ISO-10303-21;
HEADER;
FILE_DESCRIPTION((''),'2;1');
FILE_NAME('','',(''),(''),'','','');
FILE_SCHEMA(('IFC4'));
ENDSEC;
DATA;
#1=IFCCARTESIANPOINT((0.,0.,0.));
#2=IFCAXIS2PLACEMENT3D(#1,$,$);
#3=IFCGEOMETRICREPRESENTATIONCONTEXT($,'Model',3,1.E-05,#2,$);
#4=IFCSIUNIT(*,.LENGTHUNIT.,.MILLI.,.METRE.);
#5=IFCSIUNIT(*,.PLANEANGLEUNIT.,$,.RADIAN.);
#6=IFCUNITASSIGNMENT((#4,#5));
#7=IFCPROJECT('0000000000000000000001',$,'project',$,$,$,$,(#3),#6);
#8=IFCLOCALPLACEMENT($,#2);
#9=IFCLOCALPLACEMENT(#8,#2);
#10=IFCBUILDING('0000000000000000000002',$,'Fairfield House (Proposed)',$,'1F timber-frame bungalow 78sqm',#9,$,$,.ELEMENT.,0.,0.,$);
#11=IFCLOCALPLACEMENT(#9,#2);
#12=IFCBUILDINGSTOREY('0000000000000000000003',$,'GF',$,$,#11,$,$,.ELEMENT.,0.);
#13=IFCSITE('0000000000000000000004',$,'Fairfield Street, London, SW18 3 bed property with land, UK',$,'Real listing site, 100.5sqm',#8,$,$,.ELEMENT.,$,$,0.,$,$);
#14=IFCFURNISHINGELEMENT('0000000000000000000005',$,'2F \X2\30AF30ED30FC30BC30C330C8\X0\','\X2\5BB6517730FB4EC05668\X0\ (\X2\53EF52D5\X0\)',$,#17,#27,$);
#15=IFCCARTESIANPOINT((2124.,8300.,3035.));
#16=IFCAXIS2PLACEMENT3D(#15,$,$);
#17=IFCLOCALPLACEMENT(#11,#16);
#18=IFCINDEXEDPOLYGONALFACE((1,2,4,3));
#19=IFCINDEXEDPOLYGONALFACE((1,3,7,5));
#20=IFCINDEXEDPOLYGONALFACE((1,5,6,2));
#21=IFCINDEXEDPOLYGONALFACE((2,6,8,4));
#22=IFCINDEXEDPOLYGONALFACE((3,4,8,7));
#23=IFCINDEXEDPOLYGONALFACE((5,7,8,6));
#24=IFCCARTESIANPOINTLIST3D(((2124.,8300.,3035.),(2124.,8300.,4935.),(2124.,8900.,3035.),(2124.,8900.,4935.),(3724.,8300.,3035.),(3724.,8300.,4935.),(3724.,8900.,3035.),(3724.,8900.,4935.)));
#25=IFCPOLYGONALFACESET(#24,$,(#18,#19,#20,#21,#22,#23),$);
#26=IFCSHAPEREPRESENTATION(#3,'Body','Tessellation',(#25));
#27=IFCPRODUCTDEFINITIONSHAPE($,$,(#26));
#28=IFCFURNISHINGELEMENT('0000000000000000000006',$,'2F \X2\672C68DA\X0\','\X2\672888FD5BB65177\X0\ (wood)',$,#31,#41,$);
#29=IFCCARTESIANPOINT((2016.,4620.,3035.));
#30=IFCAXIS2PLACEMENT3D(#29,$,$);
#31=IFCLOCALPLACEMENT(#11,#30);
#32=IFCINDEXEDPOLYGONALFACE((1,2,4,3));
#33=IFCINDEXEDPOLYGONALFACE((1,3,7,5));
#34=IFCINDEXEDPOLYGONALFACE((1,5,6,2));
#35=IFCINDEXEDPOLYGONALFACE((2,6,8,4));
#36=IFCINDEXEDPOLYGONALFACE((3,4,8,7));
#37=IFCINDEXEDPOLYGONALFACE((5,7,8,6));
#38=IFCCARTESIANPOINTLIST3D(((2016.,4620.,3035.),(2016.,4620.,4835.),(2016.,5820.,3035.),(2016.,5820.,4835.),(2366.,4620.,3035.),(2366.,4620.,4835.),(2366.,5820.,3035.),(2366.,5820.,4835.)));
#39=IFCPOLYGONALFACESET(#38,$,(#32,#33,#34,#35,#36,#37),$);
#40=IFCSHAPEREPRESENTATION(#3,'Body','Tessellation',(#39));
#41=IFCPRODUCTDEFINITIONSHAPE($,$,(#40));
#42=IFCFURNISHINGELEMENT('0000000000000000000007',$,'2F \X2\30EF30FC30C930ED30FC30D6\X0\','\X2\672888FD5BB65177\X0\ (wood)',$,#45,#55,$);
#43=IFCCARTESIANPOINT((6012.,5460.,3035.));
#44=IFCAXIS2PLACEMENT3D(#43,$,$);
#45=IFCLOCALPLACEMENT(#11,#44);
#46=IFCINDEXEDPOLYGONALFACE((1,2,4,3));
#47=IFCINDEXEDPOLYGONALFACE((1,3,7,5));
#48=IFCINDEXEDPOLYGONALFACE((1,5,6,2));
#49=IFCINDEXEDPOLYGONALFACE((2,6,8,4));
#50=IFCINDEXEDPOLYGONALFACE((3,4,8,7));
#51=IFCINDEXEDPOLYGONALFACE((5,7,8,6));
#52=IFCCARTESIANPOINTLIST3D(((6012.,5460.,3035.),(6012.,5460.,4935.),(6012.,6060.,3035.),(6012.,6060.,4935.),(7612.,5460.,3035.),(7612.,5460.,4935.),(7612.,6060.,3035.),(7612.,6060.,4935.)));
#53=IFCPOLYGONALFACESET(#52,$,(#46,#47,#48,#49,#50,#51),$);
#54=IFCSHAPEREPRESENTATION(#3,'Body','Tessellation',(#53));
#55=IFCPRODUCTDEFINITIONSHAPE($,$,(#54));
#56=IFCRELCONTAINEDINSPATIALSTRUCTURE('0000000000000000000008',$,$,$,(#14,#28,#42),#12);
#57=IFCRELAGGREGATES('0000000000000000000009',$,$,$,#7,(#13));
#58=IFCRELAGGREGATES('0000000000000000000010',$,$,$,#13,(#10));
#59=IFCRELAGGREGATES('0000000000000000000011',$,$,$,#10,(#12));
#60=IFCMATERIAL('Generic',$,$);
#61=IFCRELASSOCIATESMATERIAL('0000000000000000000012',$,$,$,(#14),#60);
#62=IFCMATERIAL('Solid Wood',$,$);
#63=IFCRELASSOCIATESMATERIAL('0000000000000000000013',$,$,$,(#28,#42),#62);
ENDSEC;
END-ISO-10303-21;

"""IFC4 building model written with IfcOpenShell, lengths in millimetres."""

from ifc_helpers import new_model, si_unit, frame, frame_2d, origin, place, context, project, spatial, rectangle, extrude, material, element, save


model = new_model("IFC4")

# Units and contexts
model_context = context("Model", 3, precision=1e-05, world=origin())
ifc_project = project(units=[si_unit("LENGTHUNIT", "METRE", prefix="MILLI"), si_unit("PLANEANGLEUNIT", "RADIAN")], contexts=[model_context])

# Site, building, storey
site_placement = place(None, origin())
site = spatial("IfcSite", under=ifc_project, at=site_placement, Name="Fairfield Street, London, SW18 3 bed property with land, UK", ObjectType="Real listing site, 100.5sqm", CompositionType="ELEMENT", RefElevation=0.0)
building_placement = place(site_placement, origin())
building = spatial("IfcBuilding", under=site, at=building_placement, Name="Fairfield House (Proposed)", ObjectType="1F timber-frame bungalow 78sqm", CompositionType="ELEMENT", ElevationOfRefHeight=0.0, ElevationOfTerrain=0.0)
storey_placement = place(building_placement, origin())
storey = spatial("IfcBuildingStorey", under=building, at=storey_placement, Name="GF", CompositionType="ELEMENT", Elevation=0.0)

# Shared definitions
ifc_material_1 = material(Name="Solid Wood")

# Shared definitions
ifc_material_2 = material(Name="Generic")

# Furnishing elements
furnishing_1_placement = place(storey_placement, frame((2124.0, 8300.0, 3035.0)))
element("IfcFurnishingElement", 1, at=furnishing_1_placement, inside=storey, material=ifc_material_2, Name="2F クローゼット", Description="家具・什器 (可動)", context=model_context, shape_type="SweptSolid", body=[
    extrude(rectangle(XDim=1600.0, YDim=600.0, at=frame_2d((800.0, 300.0))), frame((2124.0, 8300.0, 3035.0)), (0.0, 0.0, 1.0), 1900.0),
])
furnishing_2_placement = place(storey_placement, frame((2016.0, 4620.0, 3035.0)))
element("IfcFurnishingElement", 2, at=furnishing_2_placement, inside=storey, material=ifc_material_1, Name="2F 本棚", Description="木製家具 (wood)", context=model_context, shape_type="SweptSolid", body=[
    extrude(rectangle(XDim=350.0, YDim=1200.0, at=frame_2d((175.0, 600.0))), frame((2016.0, 4620.0, 3035.0)), (0.0, 0.0, 1.0), 1800.0),
])
furnishing_3_placement = place(storey_placement, frame((6012.0, 5460.0, 3035.0)))
element("IfcFurnishingElement", 3, at=furnishing_3_placement, inside=storey, material=ifc_material_1, Name="2F ワードローブ", Description="木製家具 (wood)", context=model_context, shape_type="SweptSolid", body=[
    extrude(rectangle(XDim=1600.0, YDim=600.0, at=frame_2d((800.0, 300.0))), frame((6012.0, 5460.0, 3035.0)), (0.0, 0.0, 1.0), 1900.0),
])

save(model, "model.ifc")
